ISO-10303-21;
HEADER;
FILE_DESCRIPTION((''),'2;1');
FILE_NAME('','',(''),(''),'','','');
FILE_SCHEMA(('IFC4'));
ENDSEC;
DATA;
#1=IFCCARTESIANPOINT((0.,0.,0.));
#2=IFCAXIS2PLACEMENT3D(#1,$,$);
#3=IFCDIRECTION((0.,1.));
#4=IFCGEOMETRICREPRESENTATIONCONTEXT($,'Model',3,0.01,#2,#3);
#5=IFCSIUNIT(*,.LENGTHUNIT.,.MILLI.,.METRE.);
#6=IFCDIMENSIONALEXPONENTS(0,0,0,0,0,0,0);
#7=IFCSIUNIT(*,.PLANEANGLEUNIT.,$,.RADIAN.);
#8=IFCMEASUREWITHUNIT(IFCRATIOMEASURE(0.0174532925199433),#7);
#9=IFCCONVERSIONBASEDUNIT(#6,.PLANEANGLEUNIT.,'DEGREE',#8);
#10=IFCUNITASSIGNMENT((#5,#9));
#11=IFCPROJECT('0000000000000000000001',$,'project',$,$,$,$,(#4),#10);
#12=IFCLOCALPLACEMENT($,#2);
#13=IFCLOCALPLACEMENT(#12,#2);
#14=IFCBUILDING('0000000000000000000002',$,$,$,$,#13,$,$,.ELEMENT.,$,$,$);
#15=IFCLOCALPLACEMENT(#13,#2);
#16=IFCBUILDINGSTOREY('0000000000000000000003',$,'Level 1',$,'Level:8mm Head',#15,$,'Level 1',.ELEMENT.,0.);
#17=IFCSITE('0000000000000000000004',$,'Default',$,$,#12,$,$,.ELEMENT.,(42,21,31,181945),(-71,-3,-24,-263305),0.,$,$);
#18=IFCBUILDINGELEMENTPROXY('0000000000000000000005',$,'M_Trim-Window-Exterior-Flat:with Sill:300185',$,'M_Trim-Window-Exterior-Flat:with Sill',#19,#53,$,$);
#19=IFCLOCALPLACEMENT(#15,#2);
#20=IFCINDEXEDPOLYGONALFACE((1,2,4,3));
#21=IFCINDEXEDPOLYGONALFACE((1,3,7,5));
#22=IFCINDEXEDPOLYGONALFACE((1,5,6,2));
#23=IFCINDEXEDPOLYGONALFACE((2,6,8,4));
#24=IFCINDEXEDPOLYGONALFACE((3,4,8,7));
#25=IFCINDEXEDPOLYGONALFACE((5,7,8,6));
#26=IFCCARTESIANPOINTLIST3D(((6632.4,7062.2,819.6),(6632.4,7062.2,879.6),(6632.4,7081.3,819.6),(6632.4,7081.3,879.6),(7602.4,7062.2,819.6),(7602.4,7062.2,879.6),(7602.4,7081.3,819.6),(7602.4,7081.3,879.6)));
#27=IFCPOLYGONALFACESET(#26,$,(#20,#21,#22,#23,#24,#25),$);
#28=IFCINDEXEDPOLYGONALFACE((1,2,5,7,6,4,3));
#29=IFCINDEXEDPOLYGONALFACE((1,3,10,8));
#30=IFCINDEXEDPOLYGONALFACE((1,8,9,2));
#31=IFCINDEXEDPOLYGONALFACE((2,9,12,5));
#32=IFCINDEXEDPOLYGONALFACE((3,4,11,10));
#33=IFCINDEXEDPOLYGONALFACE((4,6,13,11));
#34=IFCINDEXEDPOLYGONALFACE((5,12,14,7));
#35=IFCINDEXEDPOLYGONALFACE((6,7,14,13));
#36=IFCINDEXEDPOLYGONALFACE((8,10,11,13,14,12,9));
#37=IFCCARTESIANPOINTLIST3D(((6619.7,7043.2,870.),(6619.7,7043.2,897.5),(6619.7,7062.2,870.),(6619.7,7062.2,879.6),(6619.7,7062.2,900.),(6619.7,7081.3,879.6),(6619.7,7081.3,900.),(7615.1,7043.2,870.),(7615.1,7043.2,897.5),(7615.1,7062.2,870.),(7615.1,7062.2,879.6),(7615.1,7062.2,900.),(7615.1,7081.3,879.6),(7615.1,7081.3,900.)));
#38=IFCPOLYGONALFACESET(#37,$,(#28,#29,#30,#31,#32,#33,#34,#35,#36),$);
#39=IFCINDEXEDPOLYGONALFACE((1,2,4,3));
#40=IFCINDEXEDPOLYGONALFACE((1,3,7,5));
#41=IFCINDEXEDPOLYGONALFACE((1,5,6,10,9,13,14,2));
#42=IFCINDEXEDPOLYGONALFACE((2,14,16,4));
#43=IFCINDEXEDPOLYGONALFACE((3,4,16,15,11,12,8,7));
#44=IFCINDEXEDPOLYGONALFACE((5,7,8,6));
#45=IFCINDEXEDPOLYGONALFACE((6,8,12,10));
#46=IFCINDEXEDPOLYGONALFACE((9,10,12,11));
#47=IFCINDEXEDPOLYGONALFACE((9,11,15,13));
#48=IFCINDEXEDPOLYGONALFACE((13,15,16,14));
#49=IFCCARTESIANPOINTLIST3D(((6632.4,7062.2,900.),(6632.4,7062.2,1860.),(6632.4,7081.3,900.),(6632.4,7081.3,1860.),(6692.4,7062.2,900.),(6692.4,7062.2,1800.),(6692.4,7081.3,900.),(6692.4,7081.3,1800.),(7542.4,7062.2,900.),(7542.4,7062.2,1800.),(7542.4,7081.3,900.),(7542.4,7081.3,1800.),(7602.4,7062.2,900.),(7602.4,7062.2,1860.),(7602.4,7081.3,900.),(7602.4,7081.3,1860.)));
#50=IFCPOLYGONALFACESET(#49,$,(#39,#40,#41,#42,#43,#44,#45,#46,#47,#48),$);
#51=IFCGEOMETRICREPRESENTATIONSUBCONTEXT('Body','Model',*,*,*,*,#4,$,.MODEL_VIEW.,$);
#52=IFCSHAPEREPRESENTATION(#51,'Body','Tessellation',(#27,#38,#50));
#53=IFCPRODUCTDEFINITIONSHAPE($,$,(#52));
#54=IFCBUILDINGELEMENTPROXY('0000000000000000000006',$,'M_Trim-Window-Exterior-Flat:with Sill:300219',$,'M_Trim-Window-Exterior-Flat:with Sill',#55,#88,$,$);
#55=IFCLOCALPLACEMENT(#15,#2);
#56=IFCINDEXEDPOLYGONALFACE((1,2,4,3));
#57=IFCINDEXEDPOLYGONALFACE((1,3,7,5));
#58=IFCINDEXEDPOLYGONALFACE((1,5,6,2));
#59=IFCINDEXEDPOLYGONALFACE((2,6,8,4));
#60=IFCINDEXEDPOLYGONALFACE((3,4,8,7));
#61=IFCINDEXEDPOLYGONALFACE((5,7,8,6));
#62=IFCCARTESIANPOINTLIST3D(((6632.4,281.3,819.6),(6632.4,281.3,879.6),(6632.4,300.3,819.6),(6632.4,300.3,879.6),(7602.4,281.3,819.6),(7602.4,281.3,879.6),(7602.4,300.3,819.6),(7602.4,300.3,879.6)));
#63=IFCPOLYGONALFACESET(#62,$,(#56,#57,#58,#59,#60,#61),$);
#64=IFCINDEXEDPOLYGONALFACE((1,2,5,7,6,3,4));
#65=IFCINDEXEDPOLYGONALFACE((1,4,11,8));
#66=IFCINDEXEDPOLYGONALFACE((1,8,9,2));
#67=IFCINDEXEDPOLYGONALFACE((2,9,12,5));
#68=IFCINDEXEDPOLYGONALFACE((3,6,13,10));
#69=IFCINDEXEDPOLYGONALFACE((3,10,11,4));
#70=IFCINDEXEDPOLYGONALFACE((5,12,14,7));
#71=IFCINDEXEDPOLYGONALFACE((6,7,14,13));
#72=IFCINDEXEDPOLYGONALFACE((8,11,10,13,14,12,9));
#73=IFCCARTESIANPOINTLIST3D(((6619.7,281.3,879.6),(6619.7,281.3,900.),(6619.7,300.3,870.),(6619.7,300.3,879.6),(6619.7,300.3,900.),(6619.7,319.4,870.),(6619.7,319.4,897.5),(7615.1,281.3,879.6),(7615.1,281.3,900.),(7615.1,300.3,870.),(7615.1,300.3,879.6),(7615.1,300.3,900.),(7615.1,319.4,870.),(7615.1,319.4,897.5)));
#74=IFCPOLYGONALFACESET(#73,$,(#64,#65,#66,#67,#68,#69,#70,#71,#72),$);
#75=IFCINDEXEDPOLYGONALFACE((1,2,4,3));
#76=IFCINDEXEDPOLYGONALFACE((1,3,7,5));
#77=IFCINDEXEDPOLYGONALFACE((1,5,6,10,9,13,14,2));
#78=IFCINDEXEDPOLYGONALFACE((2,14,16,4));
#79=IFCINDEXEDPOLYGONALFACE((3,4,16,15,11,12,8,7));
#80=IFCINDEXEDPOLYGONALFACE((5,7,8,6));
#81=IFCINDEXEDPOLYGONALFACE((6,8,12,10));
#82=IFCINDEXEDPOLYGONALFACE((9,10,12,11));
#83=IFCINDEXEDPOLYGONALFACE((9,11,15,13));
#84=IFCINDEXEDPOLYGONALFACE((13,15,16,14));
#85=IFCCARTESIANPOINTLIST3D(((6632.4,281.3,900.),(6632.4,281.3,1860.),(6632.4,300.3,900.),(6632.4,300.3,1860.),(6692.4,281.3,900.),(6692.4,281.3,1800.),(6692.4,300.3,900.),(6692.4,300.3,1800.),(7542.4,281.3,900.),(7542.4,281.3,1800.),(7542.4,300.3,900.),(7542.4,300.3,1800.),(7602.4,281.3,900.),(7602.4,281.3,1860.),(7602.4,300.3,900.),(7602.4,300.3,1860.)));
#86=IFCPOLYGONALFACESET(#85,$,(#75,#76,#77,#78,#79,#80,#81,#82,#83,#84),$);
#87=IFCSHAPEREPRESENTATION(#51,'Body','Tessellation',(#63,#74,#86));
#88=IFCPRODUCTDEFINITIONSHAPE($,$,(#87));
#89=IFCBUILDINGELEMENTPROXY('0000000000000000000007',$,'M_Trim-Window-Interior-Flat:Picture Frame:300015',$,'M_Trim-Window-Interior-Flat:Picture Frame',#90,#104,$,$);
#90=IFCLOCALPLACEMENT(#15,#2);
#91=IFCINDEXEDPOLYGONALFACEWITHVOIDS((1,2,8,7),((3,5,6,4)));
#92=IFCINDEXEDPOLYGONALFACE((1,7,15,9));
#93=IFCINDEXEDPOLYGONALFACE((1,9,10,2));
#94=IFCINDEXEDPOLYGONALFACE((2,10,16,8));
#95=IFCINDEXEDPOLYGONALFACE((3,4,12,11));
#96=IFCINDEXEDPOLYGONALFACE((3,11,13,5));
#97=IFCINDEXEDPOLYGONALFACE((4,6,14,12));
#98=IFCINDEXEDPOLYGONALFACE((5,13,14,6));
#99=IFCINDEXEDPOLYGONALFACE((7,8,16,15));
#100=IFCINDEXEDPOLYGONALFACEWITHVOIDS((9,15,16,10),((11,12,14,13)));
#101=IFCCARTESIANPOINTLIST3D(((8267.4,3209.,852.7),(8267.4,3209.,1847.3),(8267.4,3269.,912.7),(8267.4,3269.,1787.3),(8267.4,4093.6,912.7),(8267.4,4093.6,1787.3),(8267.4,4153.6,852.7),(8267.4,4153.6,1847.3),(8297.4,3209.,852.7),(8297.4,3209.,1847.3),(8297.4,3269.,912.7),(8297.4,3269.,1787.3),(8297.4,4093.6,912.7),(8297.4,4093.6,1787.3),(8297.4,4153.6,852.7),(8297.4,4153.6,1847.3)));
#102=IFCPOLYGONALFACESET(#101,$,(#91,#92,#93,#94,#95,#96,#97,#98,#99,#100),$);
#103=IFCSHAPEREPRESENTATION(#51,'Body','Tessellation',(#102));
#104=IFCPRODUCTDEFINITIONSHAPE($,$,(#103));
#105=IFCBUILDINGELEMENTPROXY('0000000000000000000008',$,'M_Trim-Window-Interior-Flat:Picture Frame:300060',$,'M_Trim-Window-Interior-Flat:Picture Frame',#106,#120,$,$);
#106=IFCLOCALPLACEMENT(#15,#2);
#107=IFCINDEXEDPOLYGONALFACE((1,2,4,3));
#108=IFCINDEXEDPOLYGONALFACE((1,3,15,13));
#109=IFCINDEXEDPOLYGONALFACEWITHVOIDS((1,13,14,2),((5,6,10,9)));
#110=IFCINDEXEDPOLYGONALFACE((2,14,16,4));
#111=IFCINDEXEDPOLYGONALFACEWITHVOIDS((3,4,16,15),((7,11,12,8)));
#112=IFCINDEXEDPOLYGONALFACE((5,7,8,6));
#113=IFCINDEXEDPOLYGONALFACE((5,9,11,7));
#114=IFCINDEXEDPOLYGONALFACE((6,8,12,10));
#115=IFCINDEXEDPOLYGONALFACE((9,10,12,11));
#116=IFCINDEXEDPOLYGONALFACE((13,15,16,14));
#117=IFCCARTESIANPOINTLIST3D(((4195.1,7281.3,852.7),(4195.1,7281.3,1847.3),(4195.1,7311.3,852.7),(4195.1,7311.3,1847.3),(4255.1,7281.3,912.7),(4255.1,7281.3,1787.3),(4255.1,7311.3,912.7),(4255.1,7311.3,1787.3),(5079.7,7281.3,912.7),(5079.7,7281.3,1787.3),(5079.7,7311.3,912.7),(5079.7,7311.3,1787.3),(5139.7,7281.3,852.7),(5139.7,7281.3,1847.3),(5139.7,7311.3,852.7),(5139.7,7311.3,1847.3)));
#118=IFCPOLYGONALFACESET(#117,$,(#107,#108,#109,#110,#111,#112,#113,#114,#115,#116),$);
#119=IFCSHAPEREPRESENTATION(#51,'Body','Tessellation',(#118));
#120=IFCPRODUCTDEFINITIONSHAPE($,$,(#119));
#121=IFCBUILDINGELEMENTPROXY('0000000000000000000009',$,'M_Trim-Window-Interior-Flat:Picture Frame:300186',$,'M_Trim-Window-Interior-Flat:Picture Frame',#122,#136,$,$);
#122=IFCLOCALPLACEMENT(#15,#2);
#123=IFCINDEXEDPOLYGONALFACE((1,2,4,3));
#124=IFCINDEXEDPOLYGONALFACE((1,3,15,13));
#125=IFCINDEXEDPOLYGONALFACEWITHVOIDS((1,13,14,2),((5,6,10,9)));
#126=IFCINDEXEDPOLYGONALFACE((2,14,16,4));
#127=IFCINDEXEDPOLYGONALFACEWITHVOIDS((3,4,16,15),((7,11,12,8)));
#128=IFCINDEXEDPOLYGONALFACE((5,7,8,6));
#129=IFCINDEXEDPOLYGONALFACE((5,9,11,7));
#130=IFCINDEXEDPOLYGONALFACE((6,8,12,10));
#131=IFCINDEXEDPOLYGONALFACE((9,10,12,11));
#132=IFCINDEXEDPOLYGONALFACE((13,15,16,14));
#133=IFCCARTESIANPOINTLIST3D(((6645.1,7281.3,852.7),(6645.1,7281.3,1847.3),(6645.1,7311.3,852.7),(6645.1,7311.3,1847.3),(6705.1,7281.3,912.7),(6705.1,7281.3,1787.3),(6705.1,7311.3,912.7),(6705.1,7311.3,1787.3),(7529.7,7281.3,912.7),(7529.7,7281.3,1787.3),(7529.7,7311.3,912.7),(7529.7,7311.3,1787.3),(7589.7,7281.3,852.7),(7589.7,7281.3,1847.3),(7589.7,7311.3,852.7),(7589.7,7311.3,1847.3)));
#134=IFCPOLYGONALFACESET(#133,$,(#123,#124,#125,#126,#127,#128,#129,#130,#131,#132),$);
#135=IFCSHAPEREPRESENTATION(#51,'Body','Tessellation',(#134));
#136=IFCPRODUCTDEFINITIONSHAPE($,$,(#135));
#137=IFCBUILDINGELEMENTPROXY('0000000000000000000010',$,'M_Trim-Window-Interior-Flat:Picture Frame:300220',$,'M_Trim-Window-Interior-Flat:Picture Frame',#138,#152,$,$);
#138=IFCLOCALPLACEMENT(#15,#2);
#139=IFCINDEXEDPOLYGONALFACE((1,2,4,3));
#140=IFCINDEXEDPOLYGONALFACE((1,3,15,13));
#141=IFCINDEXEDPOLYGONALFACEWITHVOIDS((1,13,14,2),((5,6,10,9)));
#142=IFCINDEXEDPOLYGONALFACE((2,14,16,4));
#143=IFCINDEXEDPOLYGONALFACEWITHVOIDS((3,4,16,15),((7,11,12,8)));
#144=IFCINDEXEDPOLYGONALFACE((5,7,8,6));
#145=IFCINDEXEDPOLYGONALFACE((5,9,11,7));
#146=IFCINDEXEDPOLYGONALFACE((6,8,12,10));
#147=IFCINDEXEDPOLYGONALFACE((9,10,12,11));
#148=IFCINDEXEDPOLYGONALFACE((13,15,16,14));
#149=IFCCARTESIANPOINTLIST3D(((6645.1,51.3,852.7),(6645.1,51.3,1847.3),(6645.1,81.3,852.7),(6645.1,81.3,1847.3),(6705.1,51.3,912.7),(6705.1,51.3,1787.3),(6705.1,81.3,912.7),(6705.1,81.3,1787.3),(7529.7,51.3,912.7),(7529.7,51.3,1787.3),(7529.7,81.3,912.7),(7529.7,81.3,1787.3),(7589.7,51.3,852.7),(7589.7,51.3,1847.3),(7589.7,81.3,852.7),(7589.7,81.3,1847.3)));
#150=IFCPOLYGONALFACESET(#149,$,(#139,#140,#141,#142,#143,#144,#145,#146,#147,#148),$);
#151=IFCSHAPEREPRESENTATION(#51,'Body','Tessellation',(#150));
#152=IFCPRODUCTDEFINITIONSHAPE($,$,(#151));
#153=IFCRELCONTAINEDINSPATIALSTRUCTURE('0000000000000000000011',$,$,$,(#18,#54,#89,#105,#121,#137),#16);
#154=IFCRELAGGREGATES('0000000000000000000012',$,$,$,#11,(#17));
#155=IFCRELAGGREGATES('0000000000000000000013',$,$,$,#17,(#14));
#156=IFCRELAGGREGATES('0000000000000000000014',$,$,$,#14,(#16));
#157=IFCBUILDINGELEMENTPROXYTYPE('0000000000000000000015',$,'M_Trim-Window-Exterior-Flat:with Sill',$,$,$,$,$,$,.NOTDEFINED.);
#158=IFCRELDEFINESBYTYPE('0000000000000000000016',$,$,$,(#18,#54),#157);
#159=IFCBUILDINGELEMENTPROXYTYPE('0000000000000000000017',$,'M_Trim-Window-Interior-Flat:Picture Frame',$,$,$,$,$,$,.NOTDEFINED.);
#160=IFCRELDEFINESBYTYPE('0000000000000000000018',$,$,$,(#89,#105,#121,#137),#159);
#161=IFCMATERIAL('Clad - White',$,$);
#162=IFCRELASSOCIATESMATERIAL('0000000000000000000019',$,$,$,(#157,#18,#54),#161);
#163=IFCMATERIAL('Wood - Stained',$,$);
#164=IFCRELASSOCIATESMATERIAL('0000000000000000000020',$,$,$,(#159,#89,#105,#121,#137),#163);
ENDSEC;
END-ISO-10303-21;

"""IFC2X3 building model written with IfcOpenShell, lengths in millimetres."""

from ifc_helpers import new_model, entity, si_unit, converted_unit, direction, frame, frame_2d, origin, place, context, subcontext, project, spatial, polyline, rectangle, outline, extrude, source, transform, mapped, material, type_object, type_shapes, element, save


model = new_model("IFC2X3")

# Units and contexts
model_context = context("Model", 3, precision=0.01, world=origin(), true_north=direction((0.0, 1.0)))
body_context = subcontext(model_context, "Body", "Model", "MODEL_VIEW")
ifc_project = project(units=[si_unit("LENGTHUNIT", "METRE", prefix="MILLI"), converted_unit("PLANEANGLEUNIT", "DEGREE", entity("IfcRatioMeasure", 0.0174532925199433), si_unit("PLANEANGLEUNIT", "RADIAN"), dimensions=[0, 0, 0, 0, 0, 0, 0])], contexts=[model_context])

# Site, building, storey
site_placement = place(None, origin())
site = spatial("IfcSite", under=ifc_project, at=site_placement, Name="Default", CompositionType="ELEMENT", RefLatitude=(42, 21, 31, 181945), RefLongitude=(-71, -3, -24, -263305), RefElevation=0.0)
building_placement = place(site_placement, origin())
building = spatial("IfcBuilding", under=site, at=building_placement, CompositionType="ELEMENT")
storey_placement = place(building_placement, origin())
storey = spatial("IfcBuildingStorey", under=building, at=storey_placement, Name="Level 1", ObjectType="Level:8mm Head", LongName="Level 1", CompositionType="ELEMENT", Elevation=0.0)

# Building element proxies
ifc_material_1 = material(Name="Clad - White")
ifc_material_2 = material(Name="Wood - Stained")
building_element_proxy_type_1 = type_object("IfcBuildingElementProxyType", Name="M_Trim-Window-Exterior-Flat:with Sill", PredefinedType="NOTDEFINED", material=ifc_material_1)
shared_shape_1 = source(origin(), body_context, "Body", "SweptSolid", [
    extrude(rectangle(XDim=970.0, YDim=60.0, at=frame_2d((0.0, 0.0), x_axis=(1.0, 0.0))), frame((0.0, -950.4, 0.0), z_axis=(0.0, 0.0, 1.0), x_axis=(-1.0, 0.0, 0.0)), (0.0, 0.0, 1.0), 19.1),
    extrude(outline(polyline([(-19.0, -15.2), (0.0, -15.2), (0.0, -5.7), (19.0, -5.7), (19.0, 14.8), (0.0, 14.8), (-19.0, 12.3), (-19.0, -15.2)])), frame((-497.7, -914.8, 19.0), z_axis=(1.0, 0.0, 0.0), x_axis=(0.0, 0.0, -1.0)), (0.0, 0.0, 1.0), 995.4),
    extrude(outline(polyline([(-495.0, -485.0), (465.0, -485.0), (465.0, -425.0), (-435.0, -425.0), (-435.0, 425.0), (465.0, 425.0), (465.0, 485.0), (-495.0, 485.0), (-495.0, -485.0)])), frame((0.0, -435.0, 0.0), z_axis=(0.0, 0.0, 1.0), x_axis=(0.0, -1.0, 0.0)), (0.0, 0.0, 1.0), 19.1),
])
type_shapes(building_element_proxy_type_1, [shared_shape_1])
for number, where, z_axis, x_axis, name in (
    (1, (7117.4, 7081.3, 1800.0), (0.0, -1.0, 0.0), (1.0, 0.0, 0.0), "M_Trim-Window-Exterior-Flat:with Sill:300185"),
    (2, (7117.4, 281.3, 1800.0), (0.0, 1.0, 0.0), (-1.0, 0.0, 0.0), "M_Trim-Window-Exterior-Flat:with Sill:300219"),
):
    element("IfcBuildingElementProxy", number, at=place(storey_placement, frame(where, z_axis=z_axis, x_axis=x_axis)), inside=storey, type_object=building_element_proxy_type_1, material=ifc_material_1, Name=name, ObjectType="M_Trim-Window-Exterior-Flat:with Sill", context=body_context, shape_type="MappedRepresentation", body=[
        mapped(shared_shape_1, transform((0.0, 0.0, 0.0), scale=1.0)),
    ])
building_element_proxy_type_2 = type_object("IfcBuildingElementProxyType", Name="M_Trim-Window-Interior-Flat:Picture Frame", PredefinedType="NOTDEFINED", material=ifc_material_2)
shared_shape_2 = source(origin(), body_context, "Body", "SweptSolid", [
    extrude(outline(polyline([(-472.3, -497.3), (472.3, -497.3), (472.3, 497.3), (-472.3, 497.3), (-472.3, -497.3)]), holes=[polyline([(-412.3, -437.3), (-412.3, 437.3), (412.3, 437.3), (412.3, -437.3), (-412.3, -437.3)])]), frame((0.0, -450.0, 0.0), z_axis=(0.0, 0.0, 1.0), x_axis=(-1.0, 0.0, 0.0)), (0.0, 0.0, 1.0), 30.0),
])
type_shapes(building_element_proxy_type_2, [shared_shape_2])
for number, where, z_axis, x_axis, name in (
    (3, (8267.4, 3681.3, 1800.0), (1.0, 0.0, 0.0), (0.0, 1.0, 0.0), "M_Trim-Window-Interior-Flat:Picture Frame:300015"),
    (4, (4667.4, 7281.3, 1800.0), (0.0, 1.0, 0.0), (-1.0, 0.0, 0.0), "M_Trim-Window-Interior-Flat:Picture Frame:300060"),
    (5, (7117.4, 7281.3, 1800.0), (0.0, 1.0, 0.0), (-1.0, 0.0, 0.0), "M_Trim-Window-Interior-Flat:Picture Frame:300186"),
    (6, (7117.4, 81.3, 1800.0), (0.0, -1.0, 0.0), (1.0, 0.0, 0.0), "M_Trim-Window-Interior-Flat:Picture Frame:300220"),
):
    element("IfcBuildingElementProxy", number, at=place(storey_placement, frame(where, z_axis=z_axis, x_axis=x_axis)), inside=storey, type_object=building_element_proxy_type_2, material=ifc_material_2, Name=name, ObjectType="M_Trim-Window-Interior-Flat:Picture Frame", context=body_context, shape_type="MappedRepresentation", body=[
        mapped(shared_shape_2, transform((0.0, 0.0, 0.0), scale=1.0)),
    ])

save(model, "model.ifc")
